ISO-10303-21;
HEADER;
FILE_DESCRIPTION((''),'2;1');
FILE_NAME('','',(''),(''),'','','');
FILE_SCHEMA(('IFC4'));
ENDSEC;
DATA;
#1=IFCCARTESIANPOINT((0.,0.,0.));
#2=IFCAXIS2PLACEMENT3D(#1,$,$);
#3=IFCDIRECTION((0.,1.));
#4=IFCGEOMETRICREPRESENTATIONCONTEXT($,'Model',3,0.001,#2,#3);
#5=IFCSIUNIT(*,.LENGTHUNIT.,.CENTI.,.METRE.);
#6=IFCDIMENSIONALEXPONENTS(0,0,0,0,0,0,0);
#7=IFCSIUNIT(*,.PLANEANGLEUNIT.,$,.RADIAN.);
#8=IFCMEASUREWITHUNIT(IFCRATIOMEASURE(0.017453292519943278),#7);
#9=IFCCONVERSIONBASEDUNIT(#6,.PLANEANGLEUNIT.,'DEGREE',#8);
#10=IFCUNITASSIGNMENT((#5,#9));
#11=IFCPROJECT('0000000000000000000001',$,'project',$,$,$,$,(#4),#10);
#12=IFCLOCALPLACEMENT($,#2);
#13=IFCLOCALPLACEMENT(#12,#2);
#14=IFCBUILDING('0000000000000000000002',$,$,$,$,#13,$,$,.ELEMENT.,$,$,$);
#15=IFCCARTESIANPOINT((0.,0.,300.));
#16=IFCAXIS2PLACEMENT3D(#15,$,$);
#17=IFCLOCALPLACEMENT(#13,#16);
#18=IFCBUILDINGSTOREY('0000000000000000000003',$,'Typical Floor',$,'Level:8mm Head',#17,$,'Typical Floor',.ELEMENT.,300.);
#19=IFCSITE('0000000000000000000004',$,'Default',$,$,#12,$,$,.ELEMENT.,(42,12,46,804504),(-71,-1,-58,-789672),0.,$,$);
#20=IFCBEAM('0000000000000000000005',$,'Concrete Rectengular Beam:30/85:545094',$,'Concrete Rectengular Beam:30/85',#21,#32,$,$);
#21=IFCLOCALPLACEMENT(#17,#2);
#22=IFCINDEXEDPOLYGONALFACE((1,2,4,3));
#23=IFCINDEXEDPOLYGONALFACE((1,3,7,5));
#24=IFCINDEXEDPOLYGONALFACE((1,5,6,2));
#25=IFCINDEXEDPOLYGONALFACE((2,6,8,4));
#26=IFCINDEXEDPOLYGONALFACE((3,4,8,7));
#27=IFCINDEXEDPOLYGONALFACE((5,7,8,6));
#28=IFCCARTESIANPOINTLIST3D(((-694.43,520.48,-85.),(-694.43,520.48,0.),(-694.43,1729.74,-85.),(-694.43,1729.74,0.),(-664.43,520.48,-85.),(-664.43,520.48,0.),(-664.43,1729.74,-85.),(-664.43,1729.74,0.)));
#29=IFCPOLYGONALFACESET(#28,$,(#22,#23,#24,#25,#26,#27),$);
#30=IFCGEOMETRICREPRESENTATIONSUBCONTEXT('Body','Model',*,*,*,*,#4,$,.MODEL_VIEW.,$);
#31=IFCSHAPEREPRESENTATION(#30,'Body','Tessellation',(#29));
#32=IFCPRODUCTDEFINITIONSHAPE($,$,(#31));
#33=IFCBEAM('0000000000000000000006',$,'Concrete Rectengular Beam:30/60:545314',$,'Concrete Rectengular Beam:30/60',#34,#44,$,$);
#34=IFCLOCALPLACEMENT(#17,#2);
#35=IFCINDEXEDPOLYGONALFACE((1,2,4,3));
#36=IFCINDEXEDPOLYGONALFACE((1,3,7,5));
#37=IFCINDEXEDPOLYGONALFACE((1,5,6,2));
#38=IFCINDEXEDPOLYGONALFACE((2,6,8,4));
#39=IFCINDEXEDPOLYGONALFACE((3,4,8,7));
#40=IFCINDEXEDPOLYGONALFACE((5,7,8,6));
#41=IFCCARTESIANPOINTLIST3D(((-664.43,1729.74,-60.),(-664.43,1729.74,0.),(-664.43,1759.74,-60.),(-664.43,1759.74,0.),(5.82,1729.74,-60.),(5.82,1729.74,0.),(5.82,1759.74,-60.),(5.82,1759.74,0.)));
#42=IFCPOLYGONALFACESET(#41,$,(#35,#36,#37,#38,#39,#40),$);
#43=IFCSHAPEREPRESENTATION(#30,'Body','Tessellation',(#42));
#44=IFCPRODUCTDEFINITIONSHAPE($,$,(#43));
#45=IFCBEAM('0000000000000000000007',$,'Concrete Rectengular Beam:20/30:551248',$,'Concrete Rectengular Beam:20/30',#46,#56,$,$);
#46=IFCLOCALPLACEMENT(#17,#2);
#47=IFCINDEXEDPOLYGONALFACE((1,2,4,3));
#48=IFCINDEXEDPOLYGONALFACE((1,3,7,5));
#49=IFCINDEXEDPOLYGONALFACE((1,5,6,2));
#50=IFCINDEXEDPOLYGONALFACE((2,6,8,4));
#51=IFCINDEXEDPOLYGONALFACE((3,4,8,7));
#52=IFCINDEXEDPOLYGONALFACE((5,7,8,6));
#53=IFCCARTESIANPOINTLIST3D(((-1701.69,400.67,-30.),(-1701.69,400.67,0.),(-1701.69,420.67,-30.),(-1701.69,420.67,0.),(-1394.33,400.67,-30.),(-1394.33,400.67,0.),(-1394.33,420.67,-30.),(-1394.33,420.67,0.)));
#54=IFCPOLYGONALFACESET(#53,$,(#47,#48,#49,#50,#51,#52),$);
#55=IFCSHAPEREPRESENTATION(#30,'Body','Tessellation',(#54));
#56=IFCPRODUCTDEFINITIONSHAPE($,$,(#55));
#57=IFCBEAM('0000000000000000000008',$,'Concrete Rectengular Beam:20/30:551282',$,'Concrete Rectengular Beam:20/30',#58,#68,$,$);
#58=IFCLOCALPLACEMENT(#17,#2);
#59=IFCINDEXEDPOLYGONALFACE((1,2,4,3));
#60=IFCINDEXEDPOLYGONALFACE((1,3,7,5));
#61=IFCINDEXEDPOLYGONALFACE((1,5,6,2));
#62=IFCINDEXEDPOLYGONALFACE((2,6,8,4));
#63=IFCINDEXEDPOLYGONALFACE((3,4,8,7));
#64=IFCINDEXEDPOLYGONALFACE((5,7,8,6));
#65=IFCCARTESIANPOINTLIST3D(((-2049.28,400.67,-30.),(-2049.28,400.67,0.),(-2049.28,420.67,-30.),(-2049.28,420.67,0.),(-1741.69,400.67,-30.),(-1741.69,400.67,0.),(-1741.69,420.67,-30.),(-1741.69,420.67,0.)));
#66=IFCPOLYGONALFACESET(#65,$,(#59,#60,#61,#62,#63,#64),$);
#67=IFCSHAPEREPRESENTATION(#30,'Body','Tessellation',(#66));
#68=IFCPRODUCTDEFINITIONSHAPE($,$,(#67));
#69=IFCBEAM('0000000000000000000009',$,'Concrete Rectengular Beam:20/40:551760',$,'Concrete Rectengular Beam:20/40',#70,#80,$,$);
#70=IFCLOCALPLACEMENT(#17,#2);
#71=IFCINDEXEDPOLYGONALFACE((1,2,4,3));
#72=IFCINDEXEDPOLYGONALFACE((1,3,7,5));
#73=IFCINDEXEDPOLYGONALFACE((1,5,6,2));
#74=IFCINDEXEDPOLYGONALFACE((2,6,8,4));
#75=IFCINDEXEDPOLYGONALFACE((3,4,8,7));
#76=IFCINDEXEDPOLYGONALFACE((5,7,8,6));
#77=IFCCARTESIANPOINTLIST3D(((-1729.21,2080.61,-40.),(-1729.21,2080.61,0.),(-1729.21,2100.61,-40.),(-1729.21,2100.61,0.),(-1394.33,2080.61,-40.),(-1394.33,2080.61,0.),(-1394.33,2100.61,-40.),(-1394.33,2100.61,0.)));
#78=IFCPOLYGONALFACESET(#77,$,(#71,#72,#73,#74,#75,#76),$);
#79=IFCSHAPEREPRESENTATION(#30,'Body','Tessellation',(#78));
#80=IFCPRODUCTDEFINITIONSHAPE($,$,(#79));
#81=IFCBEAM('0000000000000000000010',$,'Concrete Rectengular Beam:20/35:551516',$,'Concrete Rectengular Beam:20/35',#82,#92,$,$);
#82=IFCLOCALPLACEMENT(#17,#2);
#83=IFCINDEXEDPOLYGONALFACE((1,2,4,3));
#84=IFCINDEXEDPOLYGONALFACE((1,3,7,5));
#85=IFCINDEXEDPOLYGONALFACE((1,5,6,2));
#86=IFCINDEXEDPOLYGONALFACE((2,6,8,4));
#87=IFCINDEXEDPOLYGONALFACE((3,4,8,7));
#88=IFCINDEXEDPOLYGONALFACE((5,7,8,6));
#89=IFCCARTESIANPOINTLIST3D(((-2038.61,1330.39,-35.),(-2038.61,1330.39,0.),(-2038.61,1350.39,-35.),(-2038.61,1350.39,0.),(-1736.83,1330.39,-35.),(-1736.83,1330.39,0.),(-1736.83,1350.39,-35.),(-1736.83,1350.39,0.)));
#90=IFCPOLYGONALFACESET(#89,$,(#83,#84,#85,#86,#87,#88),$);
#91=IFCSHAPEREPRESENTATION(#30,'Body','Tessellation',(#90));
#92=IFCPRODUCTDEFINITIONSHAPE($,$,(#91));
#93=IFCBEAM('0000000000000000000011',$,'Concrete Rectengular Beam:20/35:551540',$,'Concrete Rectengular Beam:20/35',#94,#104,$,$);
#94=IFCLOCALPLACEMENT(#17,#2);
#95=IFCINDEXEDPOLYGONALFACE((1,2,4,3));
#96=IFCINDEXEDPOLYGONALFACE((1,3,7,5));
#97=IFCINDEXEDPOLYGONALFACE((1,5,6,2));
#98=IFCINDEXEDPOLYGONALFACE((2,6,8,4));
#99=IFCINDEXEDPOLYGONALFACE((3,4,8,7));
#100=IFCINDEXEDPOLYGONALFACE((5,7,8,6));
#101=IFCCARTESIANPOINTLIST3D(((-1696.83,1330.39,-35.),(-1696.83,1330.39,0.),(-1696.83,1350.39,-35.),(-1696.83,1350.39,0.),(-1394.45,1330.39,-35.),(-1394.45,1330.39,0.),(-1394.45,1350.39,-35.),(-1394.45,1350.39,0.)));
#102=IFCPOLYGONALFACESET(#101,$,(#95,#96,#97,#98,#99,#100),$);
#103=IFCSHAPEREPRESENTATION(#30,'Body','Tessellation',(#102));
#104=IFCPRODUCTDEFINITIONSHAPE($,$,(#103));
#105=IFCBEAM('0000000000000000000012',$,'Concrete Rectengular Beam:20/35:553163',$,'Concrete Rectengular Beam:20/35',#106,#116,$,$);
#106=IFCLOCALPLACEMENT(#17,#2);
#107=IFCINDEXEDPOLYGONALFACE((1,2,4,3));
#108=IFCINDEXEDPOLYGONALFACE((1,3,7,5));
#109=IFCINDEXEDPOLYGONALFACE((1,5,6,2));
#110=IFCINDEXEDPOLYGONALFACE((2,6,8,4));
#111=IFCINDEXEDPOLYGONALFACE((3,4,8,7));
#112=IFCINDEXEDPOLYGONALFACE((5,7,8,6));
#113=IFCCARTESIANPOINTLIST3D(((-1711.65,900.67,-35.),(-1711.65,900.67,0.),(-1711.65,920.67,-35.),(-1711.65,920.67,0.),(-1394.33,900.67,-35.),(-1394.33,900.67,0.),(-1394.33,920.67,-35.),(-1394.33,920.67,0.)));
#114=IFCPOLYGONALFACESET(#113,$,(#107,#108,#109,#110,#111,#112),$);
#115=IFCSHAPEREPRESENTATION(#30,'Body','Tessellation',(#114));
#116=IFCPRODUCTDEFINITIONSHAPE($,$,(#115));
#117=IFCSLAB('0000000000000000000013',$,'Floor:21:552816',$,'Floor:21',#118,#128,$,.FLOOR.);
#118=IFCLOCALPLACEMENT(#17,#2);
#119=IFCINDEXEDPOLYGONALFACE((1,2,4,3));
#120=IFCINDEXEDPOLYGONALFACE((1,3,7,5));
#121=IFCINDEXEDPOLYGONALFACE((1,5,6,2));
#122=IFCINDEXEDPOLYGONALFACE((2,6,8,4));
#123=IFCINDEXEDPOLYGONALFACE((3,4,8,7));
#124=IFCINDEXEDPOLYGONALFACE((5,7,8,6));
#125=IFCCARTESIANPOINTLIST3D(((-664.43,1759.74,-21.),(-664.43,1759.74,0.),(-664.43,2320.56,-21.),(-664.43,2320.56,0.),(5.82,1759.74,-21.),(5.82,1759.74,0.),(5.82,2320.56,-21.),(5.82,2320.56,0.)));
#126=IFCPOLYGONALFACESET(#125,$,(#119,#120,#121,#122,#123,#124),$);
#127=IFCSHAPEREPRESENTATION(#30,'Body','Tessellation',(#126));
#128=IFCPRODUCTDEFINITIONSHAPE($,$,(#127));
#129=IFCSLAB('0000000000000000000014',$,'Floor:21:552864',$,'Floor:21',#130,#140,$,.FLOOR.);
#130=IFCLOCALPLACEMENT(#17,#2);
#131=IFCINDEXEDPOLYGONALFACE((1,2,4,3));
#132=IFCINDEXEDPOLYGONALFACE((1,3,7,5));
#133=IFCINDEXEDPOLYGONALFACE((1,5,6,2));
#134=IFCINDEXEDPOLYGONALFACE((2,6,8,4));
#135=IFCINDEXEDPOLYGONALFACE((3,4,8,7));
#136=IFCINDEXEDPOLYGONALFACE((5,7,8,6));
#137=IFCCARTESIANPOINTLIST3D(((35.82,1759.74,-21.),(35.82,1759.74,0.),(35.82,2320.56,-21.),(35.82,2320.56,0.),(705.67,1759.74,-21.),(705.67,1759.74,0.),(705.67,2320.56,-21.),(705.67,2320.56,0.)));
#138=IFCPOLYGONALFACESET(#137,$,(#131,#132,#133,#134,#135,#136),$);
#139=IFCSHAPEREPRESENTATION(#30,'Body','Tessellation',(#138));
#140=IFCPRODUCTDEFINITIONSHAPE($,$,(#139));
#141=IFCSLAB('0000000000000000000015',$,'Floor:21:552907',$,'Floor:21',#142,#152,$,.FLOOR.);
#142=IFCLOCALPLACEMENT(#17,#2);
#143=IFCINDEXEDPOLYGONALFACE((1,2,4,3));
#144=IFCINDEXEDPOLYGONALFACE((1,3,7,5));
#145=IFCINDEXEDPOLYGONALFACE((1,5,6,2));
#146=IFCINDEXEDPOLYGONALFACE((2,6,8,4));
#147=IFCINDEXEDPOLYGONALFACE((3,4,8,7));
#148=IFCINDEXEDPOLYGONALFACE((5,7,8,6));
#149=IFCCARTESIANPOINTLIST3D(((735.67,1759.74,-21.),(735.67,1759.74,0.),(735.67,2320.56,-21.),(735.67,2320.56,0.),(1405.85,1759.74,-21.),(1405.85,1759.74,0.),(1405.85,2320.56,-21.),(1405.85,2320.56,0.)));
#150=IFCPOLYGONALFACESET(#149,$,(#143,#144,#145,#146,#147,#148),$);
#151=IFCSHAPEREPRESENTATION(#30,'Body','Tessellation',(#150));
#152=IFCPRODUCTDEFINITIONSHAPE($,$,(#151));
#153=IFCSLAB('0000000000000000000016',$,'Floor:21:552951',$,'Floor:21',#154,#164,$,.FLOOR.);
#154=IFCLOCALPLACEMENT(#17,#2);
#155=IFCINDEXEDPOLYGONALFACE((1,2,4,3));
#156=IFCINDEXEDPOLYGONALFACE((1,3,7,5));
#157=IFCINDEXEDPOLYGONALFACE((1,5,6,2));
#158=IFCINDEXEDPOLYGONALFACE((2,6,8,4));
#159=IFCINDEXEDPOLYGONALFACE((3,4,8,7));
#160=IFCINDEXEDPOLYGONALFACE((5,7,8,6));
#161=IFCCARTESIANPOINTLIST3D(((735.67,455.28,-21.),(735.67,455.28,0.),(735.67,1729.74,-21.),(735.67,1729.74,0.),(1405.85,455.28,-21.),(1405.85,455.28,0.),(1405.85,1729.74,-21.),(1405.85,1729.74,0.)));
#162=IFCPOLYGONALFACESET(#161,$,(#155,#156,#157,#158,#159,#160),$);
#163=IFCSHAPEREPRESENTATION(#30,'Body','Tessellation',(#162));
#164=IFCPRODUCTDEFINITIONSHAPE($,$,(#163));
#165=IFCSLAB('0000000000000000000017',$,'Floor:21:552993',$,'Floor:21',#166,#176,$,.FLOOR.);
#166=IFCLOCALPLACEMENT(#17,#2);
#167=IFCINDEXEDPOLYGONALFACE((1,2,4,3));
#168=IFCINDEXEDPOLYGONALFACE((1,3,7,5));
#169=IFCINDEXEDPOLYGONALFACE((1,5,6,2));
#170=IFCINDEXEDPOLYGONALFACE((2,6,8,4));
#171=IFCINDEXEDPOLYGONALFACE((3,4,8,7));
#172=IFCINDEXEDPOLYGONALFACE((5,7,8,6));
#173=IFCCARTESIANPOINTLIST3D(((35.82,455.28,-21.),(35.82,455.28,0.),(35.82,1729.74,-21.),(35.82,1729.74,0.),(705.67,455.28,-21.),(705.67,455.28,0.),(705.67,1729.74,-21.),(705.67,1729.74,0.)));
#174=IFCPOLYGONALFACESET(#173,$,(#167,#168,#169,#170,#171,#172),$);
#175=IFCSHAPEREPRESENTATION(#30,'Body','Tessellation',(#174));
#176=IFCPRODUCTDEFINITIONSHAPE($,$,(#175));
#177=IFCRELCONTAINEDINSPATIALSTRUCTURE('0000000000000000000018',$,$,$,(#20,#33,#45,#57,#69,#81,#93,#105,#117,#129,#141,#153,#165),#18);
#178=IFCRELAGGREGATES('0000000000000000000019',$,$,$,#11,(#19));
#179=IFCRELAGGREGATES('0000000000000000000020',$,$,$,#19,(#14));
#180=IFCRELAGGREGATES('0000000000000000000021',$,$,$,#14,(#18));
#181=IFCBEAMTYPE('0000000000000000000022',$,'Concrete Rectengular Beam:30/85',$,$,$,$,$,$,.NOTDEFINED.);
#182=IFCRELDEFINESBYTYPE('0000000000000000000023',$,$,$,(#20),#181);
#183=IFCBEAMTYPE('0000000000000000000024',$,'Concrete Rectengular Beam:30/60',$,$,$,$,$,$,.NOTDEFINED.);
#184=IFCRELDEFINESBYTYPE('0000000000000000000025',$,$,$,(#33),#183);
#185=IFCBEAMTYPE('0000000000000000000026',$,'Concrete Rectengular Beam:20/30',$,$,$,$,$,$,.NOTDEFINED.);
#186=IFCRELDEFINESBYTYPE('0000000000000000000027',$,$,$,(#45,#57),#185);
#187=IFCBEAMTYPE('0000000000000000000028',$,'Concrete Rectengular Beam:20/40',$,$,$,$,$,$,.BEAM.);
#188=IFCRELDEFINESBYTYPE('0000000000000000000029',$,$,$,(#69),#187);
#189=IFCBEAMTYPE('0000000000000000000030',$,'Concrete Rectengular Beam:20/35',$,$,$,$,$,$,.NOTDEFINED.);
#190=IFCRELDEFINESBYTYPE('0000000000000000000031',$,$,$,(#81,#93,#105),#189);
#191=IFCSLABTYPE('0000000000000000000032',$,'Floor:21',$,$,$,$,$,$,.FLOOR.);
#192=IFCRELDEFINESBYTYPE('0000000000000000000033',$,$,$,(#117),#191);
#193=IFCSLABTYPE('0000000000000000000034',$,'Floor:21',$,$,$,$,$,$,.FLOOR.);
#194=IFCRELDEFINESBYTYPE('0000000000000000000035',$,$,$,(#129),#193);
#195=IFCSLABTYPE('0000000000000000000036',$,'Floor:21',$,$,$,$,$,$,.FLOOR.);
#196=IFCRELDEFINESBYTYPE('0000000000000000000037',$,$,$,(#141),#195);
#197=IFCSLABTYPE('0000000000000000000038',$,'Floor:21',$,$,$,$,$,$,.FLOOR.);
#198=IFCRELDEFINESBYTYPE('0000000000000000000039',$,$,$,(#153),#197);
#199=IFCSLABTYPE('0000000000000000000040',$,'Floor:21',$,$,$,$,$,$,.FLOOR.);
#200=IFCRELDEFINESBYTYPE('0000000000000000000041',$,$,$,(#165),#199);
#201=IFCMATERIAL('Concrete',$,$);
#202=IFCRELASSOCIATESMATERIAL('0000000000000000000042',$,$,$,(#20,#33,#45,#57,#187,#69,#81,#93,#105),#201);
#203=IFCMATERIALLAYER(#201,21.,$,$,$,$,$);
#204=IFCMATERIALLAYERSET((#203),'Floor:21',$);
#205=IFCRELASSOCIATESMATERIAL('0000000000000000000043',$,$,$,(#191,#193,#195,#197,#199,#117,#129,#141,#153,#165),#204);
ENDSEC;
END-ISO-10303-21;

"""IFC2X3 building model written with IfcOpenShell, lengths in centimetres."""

from ifc_helpers import new_model, entity, si_unit, converted_unit, direction, frame, frame_2d, origin, origin_2d_with_axis, place, context, subcontext, project, spatial, rectangle, extrude, material, layer, layer_set, layer_usage, type_object, element, save


model = new_model("IFC2X3")

# Units and contexts
model_context = context("Model", 3, precision=0.001, world=origin(), true_north=direction((0.0, 1.0)))
body_context = subcontext(model_context, "Body", "Model", "MODEL_VIEW")
ifc_project = project(units=[si_unit("LENGTHUNIT", "METRE", prefix="CENTI"), converted_unit("PLANEANGLEUNIT", "DEGREE", entity("IfcRatioMeasure", 0.017453292519943278), si_unit("PLANEANGLEUNIT", "RADIAN"), dimensions=[0, 0, 0, 0, 0, 0, 0])], contexts=[model_context])

# Site, building, storey
site_placement = place(None, origin())
site = spatial("IfcSite", under=ifc_project, at=site_placement, Name="Default", CompositionType="ELEMENT", RefLatitude=(42, 12, 46, 804504), RefLongitude=(-71, -1, -58, -789672), RefElevation=0.0)
building_placement = place(site_placement, origin())
building = spatial("IfcBuilding", under=site, at=building_placement, CompositionType="ELEMENT")
storey_placement = place(building_placement, frame((0.0, 0.0, 300.0)))
storey = spatial("IfcBuildingStorey", under=building, at=storey_placement, Name="Typical Floor", ObjectType="Level:8mm Head", LongName="Typical Floor", CompositionType="ELEMENT", Elevation=300.0)

# Beams
ifc_material = material(Name="Concrete")
beam_type_1 = type_object("IfcBeamType", Name="Concrete Rectengular Beam:30/85", PredefinedType="NOTDEFINED")
beam_1_placement = place(storey_placement, frame((-679.43, 1744.74, 0.0), z_axis=(0.0, 0.0, 1.0), x_axis=(0.0, -1.0, 0.0)))
element("IfcBeam", 1, at=beam_1_placement, inside=storey, type_object=beam_type_1, material=ifc_material, Name="Concrete Rectengular Beam:30/85:545094", ObjectType="Concrete Rectengular Beam:30/85", context=body_context, shape_type="SweptSolid", body=[
    extrude(rectangle(XDim=85.0, YDim=30.0, at=frame_2d((0.0, 0.0), x_axis=(1.0, 0.0))), frame((15.0, 0.0, -42.5), z_axis=(1.0, 0.0, 0.0), x_axis=(0.0, 0.0, -1.0)), (0.0, 0.0, 1.0), 1209.26),
])
beam_type_2 = type_object("IfcBeamType", Name="Concrete Rectengular Beam:30/60", PredefinedType="NOTDEFINED")
beam_2_placement = place(storey_placement, frame((-679.43, 1744.74, 0.0)))
element("IfcBeam", 2, at=beam_2_placement, inside=storey, type_object=beam_type_2, material=ifc_material, Name="Concrete Rectengular Beam:30/60:545314", ObjectType="Concrete Rectengular Beam:30/60", context=body_context, shape_type="SweptSolid", body=[
    extrude(rectangle(XDim=60.0, YDim=30.0, at=frame_2d((0.0, 0.0), x_axis=(1.0, 0.0))), frame((15.0, 0.0, -30.0), z_axis=(1.0, 0.0, 0.0), x_axis=(0.0, 0.0, -1.0)), (0.0, 0.0, 1.0), 670.26),
])
beam_type_3 = type_object("IfcBeamType", Name="Concrete Rectengular Beam:20/30", PredefinedType="NOTDEFINED")
beam_3_placement = place(storey_placement, frame((-1721.69, 410.67, 0.0)))
element("IfcBeam", 3, at=beam_3_placement, inside=storey, type_object=beam_type_3, material=ifc_material, Name="Concrete Rectengular Beam:20/30:551248", ObjectType="Concrete Rectengular Beam:20/30", context=body_context, shape_type="SweptSolid", body=[
    extrude(rectangle(XDim=30.0, YDim=20.0, at=frame_2d((0.0, 0.0), x_axis=(1.0, 0.0))), frame((20.0, 0.0, -15.0), z_axis=(1.0, 0.0, 0.0), x_axis=(0.0, 0.0, -1.0)), (0.0, 0.0, 1.0), 307.37),
])
beam_4_placement = place(storey_placement, frame((-1721.69, 410.67, 0.0), z_axis=(0.0, 0.0, 1.0), x_axis=(-1.0, 0.0, 0.0)))
element("IfcBeam", 4, at=beam_4_placement, inside=storey, type_object=beam_type_3, material=ifc_material, Name="Concrete Rectengular Beam:20/30:551282", ObjectType="Concrete Rectengular Beam:20/30", context=body_context, shape_type="SweptSolid", body=[
    extrude(rectangle(XDim=30.0, YDim=20.0, at=frame_2d((0.0, 0.0), x_axis=(1.0, 0.0))), frame((20.0, 0.0, -15.0), z_axis=(1.0, 0.0, 0.0), x_axis=(0.0, 0.0, -1.0)), (0.0, 0.0, 1.0), 307.59),
])
beam_type_4 = type_object("IfcBeamType", Name="Concrete Rectengular Beam:20/40", PredefinedType="BEAM", material=ifc_material)
beam_5_placement = place(storey_placement, frame((-1739.21, 2090.61, 0.0)))
element("IfcBeam", 5, at=beam_5_placement, inside=storey, type_object=beam_type_4, material=ifc_material, Name="Concrete Rectengular Beam:20/40:551760", ObjectType="Concrete Rectengular Beam:20/40", context=body_context, shape_type="SweptSolid", body=[
    extrude(rectangle(XDim=40.0, YDim=20.0, at=frame_2d((0.0, 0.0), x_axis=(1.0, 0.0))), frame((10.0, 0.0, -20.0), z_axis=(1.0, 0.0, 0.0), x_axis=(0.0, 0.0, -1.0)), (0.0, 0.0, 1.0), 334.89),
])
beam_type_5 = type_object("IfcBeamType", Name="Concrete Rectengular Beam:20/35", PredefinedType="NOTDEFINED")
beam_6_placement = place(storey_placement, frame((-2048.61, 1340.39, 0.0)))
element("IfcBeam", 6, at=beam_6_placement, inside=storey, type_object=beam_type_5, material=ifc_material, Name="Concrete Rectengular Beam:20/35:551516", ObjectType="Concrete Rectengular Beam:20/35", context=body_context, shape_type="SweptSolid", body=[
    extrude(rectangle(XDim=35.0, YDim=20.0, at=frame_2d((0.0, 0.0), x_axis=(1.0, 0.0))), frame((10.0, 0.0, -17.5), z_axis=(1.0, 0.0, 0.0), x_axis=(0.0, 0.0, -1.0)), (0.0, 0.0, 1.0), 301.78),
])
beam_7_placement = place(storey_placement, frame((-1716.83, 1340.39, 0.0)))
element("IfcBeam", 7, at=beam_7_placement, inside=storey, type_object=beam_type_5, material=ifc_material, Name="Concrete Rectengular Beam:20/35:551540", ObjectType="Concrete Rectengular Beam:20/35", context=body_context, shape_type="SweptSolid", body=[
    extrude(rectangle(XDim=35.0, YDim=20.0, at=frame_2d((0.0, 0.0), x_axis=(1.0, 0.0))), frame((20.0, 0.0, -17.5), z_axis=(1.0, 0.0, 0.0), x_axis=(0.0, 0.0, -1.0)), (0.0, 0.0, 1.0), 302.39),
])
beam_8_placement = place(storey_placement, frame((-1731.65, 910.67, 0.0)))
element("IfcBeam", 8, at=beam_8_placement, inside=storey, type_object=beam_type_5, material=ifc_material, Name="Concrete Rectengular Beam:20/35:553163", ObjectType="Concrete Rectengular Beam:20/35", context=body_context, shape_type="SweptSolid", body=[
    extrude(rectangle(XDim=35.0, YDim=20.0, at=frame_2d((0.0, 0.0), x_axis=(1.0, 0.0))), frame((20.0, 0.0, -17.5), z_axis=(1.0, 0.0, 0.0), x_axis=(0.0, 0.0, -1.0)), (0.0, 0.0, 1.0), 317.33),
])

# Slabs
ifc_layer = layer(ifc_material, 21.0)
ifc_layer_set = layer_set([ifc_layer], Name="Floor:21")
ifc_layer_usage_1 = layer_usage(ifc_layer_set, "AXIS3", "POSITIVE", 0.0)
slab_type_1 = type_object("IfcSlabType", Name="Floor:21", PredefinedType="FLOOR", material=ifc_layer_set)
slab_1_placement = place(storey_placement, origin())
element("IfcSlab", 9, at=slab_1_placement, inside=storey, type_object=slab_type_1, material=ifc_layer_usage_1, Name="Floor:21:552816", ObjectType="Floor:21", PredefinedType="FLOOR", context=body_context, shape_type="SweptSolid", body=[
    extrude(rectangle(XDim=560.81, YDim=670.26, at=frame_2d((0.0, 0.0), x_axis=(1.0, 0.0))), frame((-329.31, 2040.15, 0.0), z_axis=(0.0, 0.0, -1.0), x_axis=(0.0, 1.0, 0.0)), (0.0, 0.0, 1.0), 21.0),
])
ifc_layer_usage_2 = layer_usage(ifc_layer_set, "AXIS3", "POSITIVE", 0.0)
slab_type_2 = type_object("IfcSlabType", Name="Floor:21", PredefinedType="FLOOR", material=ifc_layer_set)
slab_2_placement = place(storey_placement, origin())
element("IfcSlab", 10, at=slab_2_placement, inside=storey, type_object=slab_type_2, material=ifc_layer_usage_2, Name="Floor:21:552864", ObjectType="Floor:21", PredefinedType="FLOOR", context=body_context, shape_type="SweptSolid", body=[
    extrude(rectangle(XDim=560.81, YDim=669.85, at=origin_2d_with_axis()), frame((370.75, 2040.15, 0.0), z_axis=(0.0, 0.0, -1.0), x_axis=(0.0, 1.0, 0.0)), (0.0, 0.0, 1.0), 21.0),
])
ifc_layer_usage_3 = layer_usage(ifc_layer_set, "AXIS3", "POSITIVE", 0.0)
slab_type_3 = type_object("IfcSlabType", Name="Floor:21", PredefinedType="FLOOR", material=ifc_layer_set)
slab_3_placement = place(storey_placement, origin())
element("IfcSlab", 11, at=slab_3_placement, inside=storey, type_object=slab_type_3, material=ifc_layer_usage_3, Name="Floor:21:552907", ObjectType="Floor:21", PredefinedType="FLOOR", context=body_context, shape_type="SweptSolid", body=[
    extrude(rectangle(XDim=560.81, YDim=670.18, at=frame_2d((0.0, 0.0), x_axis=(1.0, 0.0))), frame((1070.76, 2040.15, 0.0), z_axis=(0.0, 0.0, -1.0), x_axis=(0.0, 1.0, 0.0)), (0.0, 0.0, 1.0), 21.0),
])
ifc_layer_usage_4 = layer_usage(ifc_layer_set, "AXIS3", "POSITIVE", 0.0)
slab_type_4 = type_object("IfcSlabType", Name="Floor:21", PredefinedType="FLOOR", material=ifc_layer_set)
slab_4_placement = place(storey_placement, origin())
element("IfcSlab", 12, at=slab_4_placement, inside=storey, type_object=slab_type_4, material=ifc_layer_usage_4, Name="Floor:21:552951", ObjectType="Floor:21", PredefinedType="FLOOR", context=body_context, shape_type="SweptSolid", body=[
    extrude(rectangle(XDim=1274.46, YDim=670.18, at=frame_2d((0.0, 0.0), x_axis=(1.0, 0.0))), frame((1070.76, 1092.51, 0.0), z_axis=(0.0, 0.0, -1.0), x_axis=(0.0, 1.0, 0.0)), (0.0, 0.0, 1.0), 21.0),
])
ifc_layer_usage_5 = layer_usage(ifc_layer_set, "AXIS3", "POSITIVE", 0.0)
slab_type_5 = type_object("IfcSlabType", Name="Floor:21", PredefinedType="FLOOR", material=ifc_layer_set)
slab_5_placement = place(storey_placement, origin())
element("IfcSlab", 13, at=slab_5_placement, inside=storey, type_object=slab_type_5, material=ifc_layer_usage_5, Name="Floor:21:552993", ObjectType="Floor:21", PredefinedType="FLOOR", context=body_context, shape_type="SweptSolid", body=[
    extrude(rectangle(XDim=1274.46, YDim=669.85, at=frame_2d((0.0, 0.0), x_axis=(1.0, 0.0))), frame((370.75, 1092.51, 0.0), z_axis=(0.0, 0.0, -1.0), x_axis=(0.0, 1.0, 0.0)), (0.0, 0.0, 1.0), 21.0),
])

save(model, "model.ifc")
